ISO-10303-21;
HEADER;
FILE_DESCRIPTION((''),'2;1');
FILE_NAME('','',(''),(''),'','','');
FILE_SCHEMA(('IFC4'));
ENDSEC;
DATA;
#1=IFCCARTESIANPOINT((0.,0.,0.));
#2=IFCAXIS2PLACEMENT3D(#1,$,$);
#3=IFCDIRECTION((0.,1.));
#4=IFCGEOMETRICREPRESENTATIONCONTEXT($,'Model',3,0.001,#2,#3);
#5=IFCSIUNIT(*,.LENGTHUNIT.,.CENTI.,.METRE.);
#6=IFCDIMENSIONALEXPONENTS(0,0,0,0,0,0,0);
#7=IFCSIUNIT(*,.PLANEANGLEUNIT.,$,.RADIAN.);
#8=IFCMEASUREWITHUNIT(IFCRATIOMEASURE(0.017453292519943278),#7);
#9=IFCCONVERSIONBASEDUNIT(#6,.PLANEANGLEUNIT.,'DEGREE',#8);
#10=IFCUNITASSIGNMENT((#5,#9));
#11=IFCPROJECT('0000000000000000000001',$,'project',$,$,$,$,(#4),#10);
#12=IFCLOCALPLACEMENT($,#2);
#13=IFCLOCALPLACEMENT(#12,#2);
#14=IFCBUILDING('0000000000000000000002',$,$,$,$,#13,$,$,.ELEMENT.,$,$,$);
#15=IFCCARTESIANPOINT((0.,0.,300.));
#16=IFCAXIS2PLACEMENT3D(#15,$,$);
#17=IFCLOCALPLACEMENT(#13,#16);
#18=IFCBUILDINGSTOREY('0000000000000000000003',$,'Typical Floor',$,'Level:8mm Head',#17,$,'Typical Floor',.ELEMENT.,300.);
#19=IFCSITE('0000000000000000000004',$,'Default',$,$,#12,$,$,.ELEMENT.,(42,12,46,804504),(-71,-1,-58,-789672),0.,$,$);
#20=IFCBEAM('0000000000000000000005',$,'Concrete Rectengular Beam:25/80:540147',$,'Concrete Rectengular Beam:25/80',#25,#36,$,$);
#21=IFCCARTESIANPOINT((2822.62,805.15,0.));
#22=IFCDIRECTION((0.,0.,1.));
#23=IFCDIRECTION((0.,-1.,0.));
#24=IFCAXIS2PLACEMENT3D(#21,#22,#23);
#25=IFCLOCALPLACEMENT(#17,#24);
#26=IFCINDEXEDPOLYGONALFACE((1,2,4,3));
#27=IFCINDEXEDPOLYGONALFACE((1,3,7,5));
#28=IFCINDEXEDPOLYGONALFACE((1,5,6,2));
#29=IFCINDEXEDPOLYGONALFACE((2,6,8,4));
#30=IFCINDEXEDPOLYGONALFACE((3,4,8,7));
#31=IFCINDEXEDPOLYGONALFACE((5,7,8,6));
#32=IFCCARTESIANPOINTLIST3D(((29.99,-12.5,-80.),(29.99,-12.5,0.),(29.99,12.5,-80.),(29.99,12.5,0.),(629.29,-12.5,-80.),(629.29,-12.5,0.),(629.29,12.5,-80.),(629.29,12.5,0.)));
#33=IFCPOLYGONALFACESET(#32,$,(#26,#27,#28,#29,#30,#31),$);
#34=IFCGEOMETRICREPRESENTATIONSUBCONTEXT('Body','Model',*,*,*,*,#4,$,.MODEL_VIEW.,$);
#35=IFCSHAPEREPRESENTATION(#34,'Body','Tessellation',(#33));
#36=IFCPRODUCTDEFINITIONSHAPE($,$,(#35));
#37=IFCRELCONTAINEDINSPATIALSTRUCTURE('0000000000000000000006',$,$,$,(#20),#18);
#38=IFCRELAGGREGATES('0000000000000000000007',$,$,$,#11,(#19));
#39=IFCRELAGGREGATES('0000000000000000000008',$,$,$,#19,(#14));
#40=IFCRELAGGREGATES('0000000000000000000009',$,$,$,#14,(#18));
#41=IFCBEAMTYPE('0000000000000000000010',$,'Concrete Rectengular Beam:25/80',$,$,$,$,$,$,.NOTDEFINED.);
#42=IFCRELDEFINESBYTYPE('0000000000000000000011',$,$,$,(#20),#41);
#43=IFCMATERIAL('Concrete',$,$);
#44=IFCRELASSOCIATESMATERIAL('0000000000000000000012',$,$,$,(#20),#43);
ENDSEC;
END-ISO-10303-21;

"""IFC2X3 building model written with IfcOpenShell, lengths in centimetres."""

from ifc_helpers import new_model, entity, si_unit, converted_unit, direction, frame, origin, origin_2d_with_axis, place, context, subcontext, project, spatial, rectangle, extrude, material, type_object, element, save


model = new_model("IFC2X3")

# Units and contexts
model_context = context("Model", 3, precision=0.001, world=origin(), true_north=direction((0.0, 1.0)))
body_context = subcontext(model_context, "Body", "Model", "MODEL_VIEW")
ifc_project = project(units=[si_unit("LENGTHUNIT", "METRE", prefix="CENTI"), converted_unit("PLANEANGLEUNIT", "DEGREE", entity("IfcRatioMeasure", 0.017453292519943278), si_unit("PLANEANGLEUNIT", "RADIAN"), dimensions=[0, 0, 0, 0, 0, 0, 0])], contexts=[model_context])

# Site, building, storey
site_placement = place(None, origin())
site = spatial("IfcSite", under=ifc_project, at=site_placement, Name="Default", CompositionType="ELEMENT", RefLatitude=(42, 12, 46, 804504), RefLongitude=(-71, -1, -58, -789672), RefElevation=0.0)
building_placement = place(site_placement, origin())
building = spatial("IfcBuilding", under=site, at=building_placement, CompositionType="ELEMENT")
storey_placement = place(building_placement, frame((0.0, 0.0, 300.0)))
storey = spatial("IfcBuildingStorey", under=building, at=storey_placement, Name="Typical Floor", ObjectType="Level:8mm Head", LongName="Typical Floor", CompositionType="ELEMENT", Elevation=300.0)

# Beam
ifc_material = material(Name="Concrete")
beam_type_1 = type_object("IfcBeamType", Name="Concrete Rectengular Beam:25/80", PredefinedType="NOTDEFINED")
beam_1_placement = place(storey_placement, frame((2822.62, 805.15, 0.0), z_axis=(0.0, 0.0, 1.0), x_axis=(0.0, -1.0, 0.0)))
element("IfcBeam", 1, at=beam_1_placement, inside=storey, type_object=beam_type_1, material=ifc_material, Name="Concrete Rectengular Beam:25/80:540147", ObjectType="Concrete Rectengular Beam:25/80", context=body_context, shape_type="SweptSolid", body=[
    extrude(rectangle(XDim=80.0, YDim=25.0, at=origin_2d_with_axis()), frame((29.99, 0.0, -40.0), z_axis=(1.0, 0.0, 0.0), x_axis=(0.0, 0.0, -1.0)), (0.0, 0.0, 1.0), 599.3),
])

save(model, "model.ifc")
